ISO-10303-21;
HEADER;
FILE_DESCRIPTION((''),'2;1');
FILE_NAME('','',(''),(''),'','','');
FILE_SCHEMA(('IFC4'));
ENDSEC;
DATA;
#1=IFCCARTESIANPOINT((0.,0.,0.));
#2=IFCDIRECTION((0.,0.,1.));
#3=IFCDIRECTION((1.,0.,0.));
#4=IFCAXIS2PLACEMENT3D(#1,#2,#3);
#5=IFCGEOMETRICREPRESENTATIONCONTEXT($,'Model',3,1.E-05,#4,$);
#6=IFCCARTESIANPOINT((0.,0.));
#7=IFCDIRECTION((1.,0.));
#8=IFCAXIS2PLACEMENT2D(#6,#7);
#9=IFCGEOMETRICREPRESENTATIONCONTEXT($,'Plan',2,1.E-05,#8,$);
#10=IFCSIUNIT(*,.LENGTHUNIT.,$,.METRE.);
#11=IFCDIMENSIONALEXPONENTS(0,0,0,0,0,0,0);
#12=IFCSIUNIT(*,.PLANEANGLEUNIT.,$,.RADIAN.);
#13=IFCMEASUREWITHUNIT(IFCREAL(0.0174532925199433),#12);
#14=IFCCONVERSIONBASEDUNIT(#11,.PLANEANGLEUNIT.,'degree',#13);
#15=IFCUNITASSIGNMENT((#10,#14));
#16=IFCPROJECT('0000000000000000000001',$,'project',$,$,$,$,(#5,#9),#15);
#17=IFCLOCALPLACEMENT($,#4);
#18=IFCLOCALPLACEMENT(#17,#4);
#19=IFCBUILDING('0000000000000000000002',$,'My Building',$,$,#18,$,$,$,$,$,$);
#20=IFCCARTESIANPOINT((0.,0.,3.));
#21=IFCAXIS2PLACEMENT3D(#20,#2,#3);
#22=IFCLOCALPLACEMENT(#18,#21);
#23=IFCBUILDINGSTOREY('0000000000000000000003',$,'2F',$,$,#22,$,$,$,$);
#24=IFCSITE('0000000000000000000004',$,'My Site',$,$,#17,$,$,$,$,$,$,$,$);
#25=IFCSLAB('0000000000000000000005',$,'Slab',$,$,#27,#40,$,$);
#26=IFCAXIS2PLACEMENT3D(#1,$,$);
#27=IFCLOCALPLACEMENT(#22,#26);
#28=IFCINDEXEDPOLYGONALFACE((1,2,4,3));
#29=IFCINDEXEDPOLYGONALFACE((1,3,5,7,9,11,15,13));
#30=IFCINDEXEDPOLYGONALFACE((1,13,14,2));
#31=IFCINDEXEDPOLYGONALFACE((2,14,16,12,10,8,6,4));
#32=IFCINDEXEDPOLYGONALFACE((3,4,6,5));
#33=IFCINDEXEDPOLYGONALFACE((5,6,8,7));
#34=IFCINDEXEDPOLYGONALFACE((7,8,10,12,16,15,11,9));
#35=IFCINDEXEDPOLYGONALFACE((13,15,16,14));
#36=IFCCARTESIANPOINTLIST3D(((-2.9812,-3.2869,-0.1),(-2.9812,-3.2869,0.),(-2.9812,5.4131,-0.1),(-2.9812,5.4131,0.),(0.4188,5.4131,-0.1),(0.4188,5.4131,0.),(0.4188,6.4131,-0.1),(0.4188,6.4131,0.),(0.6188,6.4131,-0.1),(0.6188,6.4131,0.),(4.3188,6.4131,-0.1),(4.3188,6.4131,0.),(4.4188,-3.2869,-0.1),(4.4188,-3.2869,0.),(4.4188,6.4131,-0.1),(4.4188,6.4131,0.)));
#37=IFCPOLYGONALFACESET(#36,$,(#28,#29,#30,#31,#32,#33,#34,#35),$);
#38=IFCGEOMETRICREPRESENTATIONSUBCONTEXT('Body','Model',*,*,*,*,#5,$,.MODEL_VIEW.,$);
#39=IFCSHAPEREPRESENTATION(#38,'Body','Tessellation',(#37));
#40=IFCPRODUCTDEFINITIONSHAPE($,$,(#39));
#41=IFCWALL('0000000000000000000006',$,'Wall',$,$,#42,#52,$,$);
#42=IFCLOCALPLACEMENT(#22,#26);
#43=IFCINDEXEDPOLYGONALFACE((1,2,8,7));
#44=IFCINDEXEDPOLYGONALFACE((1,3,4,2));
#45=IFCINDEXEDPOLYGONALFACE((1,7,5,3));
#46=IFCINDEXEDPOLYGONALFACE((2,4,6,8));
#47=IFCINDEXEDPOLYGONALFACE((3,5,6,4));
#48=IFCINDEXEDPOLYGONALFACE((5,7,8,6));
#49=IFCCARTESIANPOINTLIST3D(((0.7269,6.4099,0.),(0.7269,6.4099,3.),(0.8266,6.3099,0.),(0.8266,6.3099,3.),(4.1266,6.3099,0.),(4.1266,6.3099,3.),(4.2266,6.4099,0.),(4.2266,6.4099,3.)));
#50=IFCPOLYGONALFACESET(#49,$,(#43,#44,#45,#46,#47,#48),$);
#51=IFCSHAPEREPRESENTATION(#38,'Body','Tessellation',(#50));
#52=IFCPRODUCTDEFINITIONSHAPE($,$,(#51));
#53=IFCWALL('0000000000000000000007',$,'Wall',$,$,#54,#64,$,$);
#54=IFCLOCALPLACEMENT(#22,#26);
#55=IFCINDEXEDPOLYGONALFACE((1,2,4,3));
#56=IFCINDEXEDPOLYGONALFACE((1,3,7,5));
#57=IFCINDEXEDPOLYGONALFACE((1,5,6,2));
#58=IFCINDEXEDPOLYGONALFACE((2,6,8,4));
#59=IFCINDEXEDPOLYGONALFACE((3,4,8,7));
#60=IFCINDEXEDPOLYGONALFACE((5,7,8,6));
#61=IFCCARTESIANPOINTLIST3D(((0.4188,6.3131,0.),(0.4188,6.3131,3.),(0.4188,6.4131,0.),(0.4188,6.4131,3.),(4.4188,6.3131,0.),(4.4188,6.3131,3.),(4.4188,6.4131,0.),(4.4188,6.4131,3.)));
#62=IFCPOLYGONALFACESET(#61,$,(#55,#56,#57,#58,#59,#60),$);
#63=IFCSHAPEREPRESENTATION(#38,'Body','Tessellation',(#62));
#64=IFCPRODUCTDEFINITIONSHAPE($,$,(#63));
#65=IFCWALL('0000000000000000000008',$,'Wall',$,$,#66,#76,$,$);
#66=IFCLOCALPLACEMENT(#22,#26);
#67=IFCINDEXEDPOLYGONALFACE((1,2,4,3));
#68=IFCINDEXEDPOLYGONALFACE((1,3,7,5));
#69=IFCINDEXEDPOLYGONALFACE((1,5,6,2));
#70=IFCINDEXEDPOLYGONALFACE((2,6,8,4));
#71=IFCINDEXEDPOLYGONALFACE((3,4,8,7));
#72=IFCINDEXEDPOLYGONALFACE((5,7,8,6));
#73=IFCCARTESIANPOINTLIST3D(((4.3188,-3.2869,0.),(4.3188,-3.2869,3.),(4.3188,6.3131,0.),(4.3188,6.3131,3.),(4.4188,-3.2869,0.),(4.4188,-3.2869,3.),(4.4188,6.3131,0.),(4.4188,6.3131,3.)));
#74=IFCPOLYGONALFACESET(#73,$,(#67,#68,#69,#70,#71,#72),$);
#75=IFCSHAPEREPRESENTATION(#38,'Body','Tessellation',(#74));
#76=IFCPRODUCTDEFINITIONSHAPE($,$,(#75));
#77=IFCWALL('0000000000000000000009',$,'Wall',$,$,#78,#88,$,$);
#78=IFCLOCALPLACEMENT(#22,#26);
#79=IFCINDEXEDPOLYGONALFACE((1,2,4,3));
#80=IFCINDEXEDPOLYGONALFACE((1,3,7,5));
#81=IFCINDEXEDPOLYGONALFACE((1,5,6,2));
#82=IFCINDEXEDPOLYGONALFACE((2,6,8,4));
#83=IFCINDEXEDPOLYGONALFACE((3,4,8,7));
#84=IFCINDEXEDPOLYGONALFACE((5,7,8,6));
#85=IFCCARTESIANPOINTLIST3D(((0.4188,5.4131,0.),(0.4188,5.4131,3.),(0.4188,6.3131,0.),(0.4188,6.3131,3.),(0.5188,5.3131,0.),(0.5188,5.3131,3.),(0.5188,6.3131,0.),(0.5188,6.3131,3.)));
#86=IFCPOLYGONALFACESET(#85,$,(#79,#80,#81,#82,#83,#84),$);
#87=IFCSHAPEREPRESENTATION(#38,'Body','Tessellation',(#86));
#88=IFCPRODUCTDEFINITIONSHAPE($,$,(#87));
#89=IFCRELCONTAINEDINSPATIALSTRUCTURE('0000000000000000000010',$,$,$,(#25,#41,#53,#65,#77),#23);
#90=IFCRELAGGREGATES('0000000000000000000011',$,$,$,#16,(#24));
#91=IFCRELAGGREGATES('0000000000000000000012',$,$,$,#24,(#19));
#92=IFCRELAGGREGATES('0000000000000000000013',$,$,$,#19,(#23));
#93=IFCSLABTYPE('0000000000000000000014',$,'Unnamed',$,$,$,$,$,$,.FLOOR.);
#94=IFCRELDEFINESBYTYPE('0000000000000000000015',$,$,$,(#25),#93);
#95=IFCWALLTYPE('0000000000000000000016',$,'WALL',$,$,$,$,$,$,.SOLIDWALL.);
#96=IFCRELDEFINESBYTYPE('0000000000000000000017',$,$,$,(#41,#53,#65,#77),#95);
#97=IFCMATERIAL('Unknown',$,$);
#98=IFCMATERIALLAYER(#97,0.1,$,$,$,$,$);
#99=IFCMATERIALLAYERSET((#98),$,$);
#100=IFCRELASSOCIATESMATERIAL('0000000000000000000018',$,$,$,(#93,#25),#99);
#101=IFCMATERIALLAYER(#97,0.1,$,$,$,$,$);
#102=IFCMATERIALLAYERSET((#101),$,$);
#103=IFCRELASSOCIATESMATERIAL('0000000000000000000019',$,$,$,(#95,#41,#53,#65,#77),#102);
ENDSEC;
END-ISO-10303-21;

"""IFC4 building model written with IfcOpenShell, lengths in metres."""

from ifc_helpers import new_model, entity, si_unit, converted_unit, frame, origin_with_axes, origin_2d_with_axis, place, context, subcontext, project, spatial, line, indexed_curve, outline, extrude, material, layer, layer_set, layer_usage, type_object, element, save


model = new_model("IFC4")

# Units and contexts
model_context = context("Model", 3, precision=1e-05, world=origin_with_axes())
plan_context = context("Plan", 2, precision=1e-05, world=origin_2d_with_axis())
body_context_1 = subcontext(model_context, "Body", "Model", "MODEL_VIEW")
ifc_project = project(units=[si_unit("LENGTHUNIT", "METRE"), converted_unit("PLANEANGLEUNIT", "degree", entity("IfcReal", 0.0174532925199433), si_unit("PLANEANGLEUNIT", "RADIAN"), dimensions=[0, 0, 0, 0, 0, 0, 0])], contexts=[model_context, plan_context])

# Site, building, storey
site_placement = place(None, origin_with_axes())
site = spatial("IfcSite", under=ifc_project, at=site_placement, Name="My Site")
building_placement = place(site_placement, origin_with_axes())
building = spatial("IfcBuilding", under=site, at=building_placement, Name="My Building")
storey_placement = place(building_placement, frame((0.0, 0.0, 3.0), z_axis=(0.0, 0.0, 1.0), x_axis=(1.0, 0.0, 0.0)))
storey = spatial("IfcBuildingStorey", under=building, at=storey_placement, Name="2F")

# Slab
ifc_material = material(Name="Unknown")
ifc_layer_1 = layer(ifc_material, 0.1)
ifc_layer_set_1 = layer_set([ifc_layer_1])
ifc_layer_usage_1 = layer_usage(ifc_layer_set_1, "AXIS3", "POSITIVE", -0.1)
slab_type = type_object("IfcSlabType", Name="Unnamed", PredefinedType="FLOOR", material=ifc_layer_set_1)
slab_placement = place(storey_placement, frame((0.6188, 6.4131, 0.0), z_axis=(0.0, 0.0, 1.0), x_axis=(1.0, 0.0, 0.0)))
element("IfcSlab", 1, at=slab_placement, inside=storey, type_object=slab_type, material=ifc_layer_usage_1, Name="Slab", context=body_context_1, shape_type="SweptSolid", body=[
    extrude(outline(indexed_curve([(0.0, 0.0), (3.7, 0.0), (3.8, 0.0), (3.8, -9.7), (-3.6, -9.7), (-3.6, -1.0), (-0.2, -1.0), (-0.2, 0.0), (0.0, 0.0)])), frame((0.0, 0.0, -0.1), z_axis=(0.0, 0.0, 1.0), x_axis=(1.0, 0.0, 0.0)), (0.0, 0.0, 1.0), 0.1),
])

# Walls
ifc_layer_2 = layer(ifc_material, 0.1)
ifc_layer_set_2 = layer_set([ifc_layer_2])
ifc_layer_usage_2 = layer_usage(ifc_layer_set_2, "AXIS2", "POSITIVE", 0.0)
wall_type = type_object("IfcWallType", Name="WALL", PredefinedType="SOLIDWALL", material=ifc_layer_set_2)
wall_1_placement = place(storey_placement, frame((0.8266, 6.3099, 0.0), z_axis=(0.0, 0.0, 1.0), x_axis=(1.0, 0.0, 0.0)))
element("IfcWall", 2, at=wall_1_placement, inside=storey, type_object=wall_type, material=ifc_layer_usage_2, Name="Wall", context=body_context_1, shape_type="SweptSolid", body=[
    extrude(outline(indexed_curve([(0.0, 0.0), (-0.0997, 0.1), (3.4, 0.1), (3.3, 0.0)], segments=[line(1, 2, 3, 4, 1)])), origin_with_axes(), (0.0, 0.0, 1.0), 3.0),
])
ifc_layer_usage_3 = layer_usage(ifc_layer_set_2, "AXIS2", "POSITIVE", 0.0)
wall_2_placement = place(storey_placement, frame((0.4188, 6.3131, 0.0), z_axis=(0.0, 0.0, 1.0), x_axis=(1.0, 0.0, 0.0)))
element("IfcWall", 3, at=wall_2_placement, inside=storey, type_object=wall_type, material=ifc_layer_usage_3, Name="Wall", context=body_context_1, shape_type="SweptSolid", body=[
    extrude(outline(indexed_curve([(0.0, 0.0), (0.0, 0.1), (4.0, 0.1), (4.0, 0.0)], segments=[line(1, 2, 3, 4, 1)])), origin_with_axes(), (0.0, 0.0, 1.0), 3.0),
])
ifc_layer_usage_4 = layer_usage(ifc_layer_set_2, "AXIS2", "POSITIVE", 0.0)
wall_3_placement = place(storey_placement, frame((4.3188, 6.3131, 0.0), z_axis=(0.0, 0.0, 1.0), x_axis=(0.0, -1.0, 0.0)))
element("IfcWall", 4, at=wall_3_placement, inside=storey, type_object=wall_type, material=ifc_layer_usage_4, Name="Wall", context=body_context_1, shape_type="SweptSolid", body=[
    extrude(outline(indexed_curve([(0.0, 0.0), (0.0, 0.1), (9.6, 0.1), (9.6, 0.0)], segments=[line(1, 2, 3, 4, 1)])), origin_with_axes(), (0.0, 0.0, 1.0), 3.0),
])
ifc_layer_usage_5 = layer_usage(ifc_layer_set_2, "AXIS2", "POSITIVE", 0.0)
wall_4_placement = place(storey_placement, frame((0.4188, 6.3131, 0.0), z_axis=(0.0, 0.0, 1.0), x_axis=(0.0, -1.0, 0.0)))
element("IfcWall", 5, at=wall_4_placement, inside=storey, type_object=wall_type, material=ifc_layer_usage_5, Name="Wall", context=body_context_1, shape_type="SweptSolid", body=[
    extrude(outline(indexed_curve([(0.0, 0.0), (0.0, 0.1), (1.0, 0.1), (0.9, 0.0)], segments=[line(1, 2, 3, 4, 1)])), origin_with_axes(), (0.0, 0.0, 1.0), 3.0),
])

save(model, "model.ifc")
